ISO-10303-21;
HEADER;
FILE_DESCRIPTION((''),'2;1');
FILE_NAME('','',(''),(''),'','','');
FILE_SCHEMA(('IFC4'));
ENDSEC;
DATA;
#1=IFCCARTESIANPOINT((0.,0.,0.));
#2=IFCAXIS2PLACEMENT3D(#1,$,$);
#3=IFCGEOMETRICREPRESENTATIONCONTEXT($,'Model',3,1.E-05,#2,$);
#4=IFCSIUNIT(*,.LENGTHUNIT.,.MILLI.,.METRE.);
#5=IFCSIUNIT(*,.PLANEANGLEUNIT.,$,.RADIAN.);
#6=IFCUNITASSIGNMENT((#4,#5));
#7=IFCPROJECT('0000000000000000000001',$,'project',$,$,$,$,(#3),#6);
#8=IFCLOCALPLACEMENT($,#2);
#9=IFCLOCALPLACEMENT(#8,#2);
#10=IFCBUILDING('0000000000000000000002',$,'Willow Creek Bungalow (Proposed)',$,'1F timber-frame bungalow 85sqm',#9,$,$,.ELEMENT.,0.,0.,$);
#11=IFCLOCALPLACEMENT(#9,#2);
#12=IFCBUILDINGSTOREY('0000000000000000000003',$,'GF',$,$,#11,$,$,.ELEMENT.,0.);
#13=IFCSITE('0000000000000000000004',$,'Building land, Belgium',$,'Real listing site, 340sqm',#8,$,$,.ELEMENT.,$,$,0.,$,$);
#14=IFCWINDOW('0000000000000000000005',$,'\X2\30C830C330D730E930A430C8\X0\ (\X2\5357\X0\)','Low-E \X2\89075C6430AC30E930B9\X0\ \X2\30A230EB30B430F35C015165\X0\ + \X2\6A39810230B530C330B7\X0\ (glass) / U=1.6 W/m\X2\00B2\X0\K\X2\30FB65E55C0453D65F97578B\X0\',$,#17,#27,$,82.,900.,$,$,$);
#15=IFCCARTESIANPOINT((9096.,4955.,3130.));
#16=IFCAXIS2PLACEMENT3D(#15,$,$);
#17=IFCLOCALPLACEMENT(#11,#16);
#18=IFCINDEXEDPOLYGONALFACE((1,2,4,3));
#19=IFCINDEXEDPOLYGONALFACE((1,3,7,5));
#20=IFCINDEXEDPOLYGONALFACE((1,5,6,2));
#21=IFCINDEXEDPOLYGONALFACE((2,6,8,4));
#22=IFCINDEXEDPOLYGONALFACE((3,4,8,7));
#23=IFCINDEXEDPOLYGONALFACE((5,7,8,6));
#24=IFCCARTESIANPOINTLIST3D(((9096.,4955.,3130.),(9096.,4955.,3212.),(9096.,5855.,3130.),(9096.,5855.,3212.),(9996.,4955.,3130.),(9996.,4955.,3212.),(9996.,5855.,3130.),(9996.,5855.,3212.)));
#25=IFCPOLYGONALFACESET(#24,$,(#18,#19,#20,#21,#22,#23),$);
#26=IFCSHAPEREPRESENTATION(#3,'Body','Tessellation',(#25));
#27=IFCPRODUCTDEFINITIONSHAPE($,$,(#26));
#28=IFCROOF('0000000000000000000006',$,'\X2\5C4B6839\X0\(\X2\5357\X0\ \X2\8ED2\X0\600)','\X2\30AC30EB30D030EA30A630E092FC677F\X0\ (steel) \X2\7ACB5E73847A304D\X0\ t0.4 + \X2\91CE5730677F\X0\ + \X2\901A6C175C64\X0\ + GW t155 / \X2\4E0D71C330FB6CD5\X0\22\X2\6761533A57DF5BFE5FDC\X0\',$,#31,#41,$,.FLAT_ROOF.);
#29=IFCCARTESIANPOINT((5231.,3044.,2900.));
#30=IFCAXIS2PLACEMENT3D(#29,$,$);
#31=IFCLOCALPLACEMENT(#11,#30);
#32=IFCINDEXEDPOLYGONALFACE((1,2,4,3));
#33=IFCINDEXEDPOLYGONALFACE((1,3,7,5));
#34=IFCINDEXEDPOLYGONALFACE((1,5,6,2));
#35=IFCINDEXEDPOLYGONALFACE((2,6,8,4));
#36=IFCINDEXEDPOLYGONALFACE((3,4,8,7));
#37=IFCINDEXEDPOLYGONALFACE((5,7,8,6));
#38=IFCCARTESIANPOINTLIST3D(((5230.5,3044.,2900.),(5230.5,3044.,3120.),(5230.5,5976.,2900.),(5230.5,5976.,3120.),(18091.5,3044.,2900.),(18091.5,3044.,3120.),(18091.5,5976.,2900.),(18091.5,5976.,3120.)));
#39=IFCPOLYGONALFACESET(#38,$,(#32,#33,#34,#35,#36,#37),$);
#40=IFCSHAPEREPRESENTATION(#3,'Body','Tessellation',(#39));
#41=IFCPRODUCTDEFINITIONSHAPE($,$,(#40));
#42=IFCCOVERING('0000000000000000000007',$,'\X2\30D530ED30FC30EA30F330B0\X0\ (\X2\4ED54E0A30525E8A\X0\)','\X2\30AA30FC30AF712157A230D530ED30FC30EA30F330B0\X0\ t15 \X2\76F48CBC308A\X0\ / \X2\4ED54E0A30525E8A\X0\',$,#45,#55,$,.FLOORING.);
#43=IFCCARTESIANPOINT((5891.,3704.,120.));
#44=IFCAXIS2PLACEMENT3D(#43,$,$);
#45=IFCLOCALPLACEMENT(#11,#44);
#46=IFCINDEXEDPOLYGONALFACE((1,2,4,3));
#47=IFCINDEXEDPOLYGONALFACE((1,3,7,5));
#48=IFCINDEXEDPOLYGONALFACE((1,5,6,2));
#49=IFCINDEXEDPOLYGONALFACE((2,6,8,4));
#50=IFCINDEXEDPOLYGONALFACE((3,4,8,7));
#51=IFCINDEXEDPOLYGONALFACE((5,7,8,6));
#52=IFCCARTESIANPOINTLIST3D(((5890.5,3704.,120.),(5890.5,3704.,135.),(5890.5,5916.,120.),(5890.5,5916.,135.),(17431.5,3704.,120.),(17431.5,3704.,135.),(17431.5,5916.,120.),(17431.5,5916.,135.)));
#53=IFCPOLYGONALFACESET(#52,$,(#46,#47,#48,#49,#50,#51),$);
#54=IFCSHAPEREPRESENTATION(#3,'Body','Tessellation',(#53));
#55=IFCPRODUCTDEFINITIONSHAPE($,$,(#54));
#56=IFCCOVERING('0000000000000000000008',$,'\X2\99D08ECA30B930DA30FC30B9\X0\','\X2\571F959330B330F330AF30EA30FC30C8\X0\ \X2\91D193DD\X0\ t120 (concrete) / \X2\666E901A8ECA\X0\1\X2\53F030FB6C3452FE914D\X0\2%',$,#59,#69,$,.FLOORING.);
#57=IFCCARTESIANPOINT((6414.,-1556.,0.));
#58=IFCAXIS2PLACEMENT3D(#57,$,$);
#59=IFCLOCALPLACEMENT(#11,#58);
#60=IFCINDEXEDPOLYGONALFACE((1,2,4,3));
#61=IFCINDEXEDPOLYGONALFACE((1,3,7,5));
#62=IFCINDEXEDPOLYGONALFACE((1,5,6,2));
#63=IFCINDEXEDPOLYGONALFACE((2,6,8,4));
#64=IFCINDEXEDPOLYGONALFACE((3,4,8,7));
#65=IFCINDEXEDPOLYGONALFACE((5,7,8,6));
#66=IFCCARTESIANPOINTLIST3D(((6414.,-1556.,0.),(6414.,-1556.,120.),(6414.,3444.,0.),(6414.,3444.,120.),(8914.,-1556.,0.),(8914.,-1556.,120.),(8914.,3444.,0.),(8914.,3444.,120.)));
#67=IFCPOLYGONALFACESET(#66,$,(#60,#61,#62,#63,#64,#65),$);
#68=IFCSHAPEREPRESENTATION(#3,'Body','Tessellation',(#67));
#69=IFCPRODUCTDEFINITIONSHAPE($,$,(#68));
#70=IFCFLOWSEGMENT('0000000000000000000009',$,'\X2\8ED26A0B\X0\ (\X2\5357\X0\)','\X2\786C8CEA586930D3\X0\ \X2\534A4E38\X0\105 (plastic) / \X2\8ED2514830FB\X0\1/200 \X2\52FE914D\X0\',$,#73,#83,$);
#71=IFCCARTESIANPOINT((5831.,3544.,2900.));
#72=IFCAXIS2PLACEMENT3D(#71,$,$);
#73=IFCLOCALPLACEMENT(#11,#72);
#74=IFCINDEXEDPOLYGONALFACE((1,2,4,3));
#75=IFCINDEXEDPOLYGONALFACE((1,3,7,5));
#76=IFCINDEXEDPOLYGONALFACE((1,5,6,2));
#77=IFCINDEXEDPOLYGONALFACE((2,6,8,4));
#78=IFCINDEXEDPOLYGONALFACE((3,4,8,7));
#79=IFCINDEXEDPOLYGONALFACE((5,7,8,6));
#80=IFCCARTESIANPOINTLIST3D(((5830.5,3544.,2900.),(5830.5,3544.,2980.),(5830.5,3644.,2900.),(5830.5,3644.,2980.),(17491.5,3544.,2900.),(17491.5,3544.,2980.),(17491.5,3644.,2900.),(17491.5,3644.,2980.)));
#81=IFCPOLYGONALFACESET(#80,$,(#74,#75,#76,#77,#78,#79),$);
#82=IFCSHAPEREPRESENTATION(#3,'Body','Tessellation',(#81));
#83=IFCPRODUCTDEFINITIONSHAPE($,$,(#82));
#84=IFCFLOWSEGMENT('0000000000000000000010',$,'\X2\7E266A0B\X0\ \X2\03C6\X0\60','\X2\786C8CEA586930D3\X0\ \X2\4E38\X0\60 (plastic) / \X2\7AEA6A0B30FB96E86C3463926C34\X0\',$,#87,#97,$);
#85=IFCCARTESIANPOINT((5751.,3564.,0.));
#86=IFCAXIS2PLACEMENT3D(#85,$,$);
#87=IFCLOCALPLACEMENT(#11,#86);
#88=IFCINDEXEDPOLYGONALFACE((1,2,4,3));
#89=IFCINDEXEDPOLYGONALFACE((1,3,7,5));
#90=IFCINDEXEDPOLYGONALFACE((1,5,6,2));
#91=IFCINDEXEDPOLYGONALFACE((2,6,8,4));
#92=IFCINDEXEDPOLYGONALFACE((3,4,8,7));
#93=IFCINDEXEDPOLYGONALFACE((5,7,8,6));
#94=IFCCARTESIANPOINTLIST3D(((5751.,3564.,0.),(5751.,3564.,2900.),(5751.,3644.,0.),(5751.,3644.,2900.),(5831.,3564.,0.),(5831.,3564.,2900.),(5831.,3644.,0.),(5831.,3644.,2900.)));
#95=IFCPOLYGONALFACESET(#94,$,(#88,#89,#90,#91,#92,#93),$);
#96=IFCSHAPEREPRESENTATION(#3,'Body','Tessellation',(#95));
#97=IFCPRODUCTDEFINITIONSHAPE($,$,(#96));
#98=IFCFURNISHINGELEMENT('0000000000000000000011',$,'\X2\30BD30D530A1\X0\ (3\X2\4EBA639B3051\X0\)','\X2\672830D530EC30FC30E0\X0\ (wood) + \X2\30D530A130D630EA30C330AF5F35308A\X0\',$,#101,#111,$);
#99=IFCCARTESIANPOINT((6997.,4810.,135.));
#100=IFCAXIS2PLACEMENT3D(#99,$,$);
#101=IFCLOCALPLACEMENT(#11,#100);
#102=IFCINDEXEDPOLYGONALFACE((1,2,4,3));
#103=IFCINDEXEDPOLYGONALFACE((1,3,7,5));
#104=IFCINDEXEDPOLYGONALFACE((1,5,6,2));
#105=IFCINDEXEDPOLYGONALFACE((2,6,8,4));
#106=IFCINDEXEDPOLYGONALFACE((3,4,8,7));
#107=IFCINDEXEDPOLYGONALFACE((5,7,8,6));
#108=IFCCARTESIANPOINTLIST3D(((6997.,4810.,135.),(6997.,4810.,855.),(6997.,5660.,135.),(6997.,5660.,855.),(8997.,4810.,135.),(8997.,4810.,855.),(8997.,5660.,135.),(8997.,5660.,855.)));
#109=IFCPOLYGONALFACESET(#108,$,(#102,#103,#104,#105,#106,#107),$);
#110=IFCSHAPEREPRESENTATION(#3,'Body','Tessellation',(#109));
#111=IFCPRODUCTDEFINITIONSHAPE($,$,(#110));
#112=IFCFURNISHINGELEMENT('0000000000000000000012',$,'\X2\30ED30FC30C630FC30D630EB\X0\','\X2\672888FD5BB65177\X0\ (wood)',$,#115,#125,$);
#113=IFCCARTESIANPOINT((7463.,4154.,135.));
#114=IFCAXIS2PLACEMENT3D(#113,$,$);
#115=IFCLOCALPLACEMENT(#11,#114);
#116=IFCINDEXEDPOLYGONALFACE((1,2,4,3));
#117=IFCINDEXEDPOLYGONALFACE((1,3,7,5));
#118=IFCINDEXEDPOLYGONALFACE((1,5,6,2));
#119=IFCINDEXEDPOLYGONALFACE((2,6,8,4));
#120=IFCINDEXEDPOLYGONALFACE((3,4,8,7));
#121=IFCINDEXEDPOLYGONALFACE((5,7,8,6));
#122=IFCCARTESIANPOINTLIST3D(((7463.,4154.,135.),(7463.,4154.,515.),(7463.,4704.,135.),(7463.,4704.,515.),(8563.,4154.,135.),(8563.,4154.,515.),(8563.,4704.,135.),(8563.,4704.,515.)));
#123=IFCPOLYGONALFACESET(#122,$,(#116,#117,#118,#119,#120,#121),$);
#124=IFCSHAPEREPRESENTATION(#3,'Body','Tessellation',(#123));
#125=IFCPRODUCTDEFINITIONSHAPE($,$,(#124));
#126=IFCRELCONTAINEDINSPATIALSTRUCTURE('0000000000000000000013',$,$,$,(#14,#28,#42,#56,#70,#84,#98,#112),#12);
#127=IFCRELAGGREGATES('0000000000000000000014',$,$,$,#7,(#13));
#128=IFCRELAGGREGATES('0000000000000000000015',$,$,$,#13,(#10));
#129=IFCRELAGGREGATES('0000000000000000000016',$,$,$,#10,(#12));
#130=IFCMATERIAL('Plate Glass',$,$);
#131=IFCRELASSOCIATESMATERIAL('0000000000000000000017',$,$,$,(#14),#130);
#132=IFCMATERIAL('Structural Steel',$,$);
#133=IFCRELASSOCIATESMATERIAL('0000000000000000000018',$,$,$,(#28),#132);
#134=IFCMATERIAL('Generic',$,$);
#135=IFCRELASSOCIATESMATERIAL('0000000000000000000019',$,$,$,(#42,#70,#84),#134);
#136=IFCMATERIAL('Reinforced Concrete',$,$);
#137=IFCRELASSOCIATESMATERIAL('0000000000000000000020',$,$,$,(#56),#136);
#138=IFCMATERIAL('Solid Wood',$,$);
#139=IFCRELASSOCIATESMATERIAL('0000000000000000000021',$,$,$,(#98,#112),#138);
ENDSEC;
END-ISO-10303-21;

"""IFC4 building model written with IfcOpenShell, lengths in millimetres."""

from ifc_helpers import new_model, si_unit, frame, frame_2d, origin, place, context, project, spatial, rectangle, extrude, material, element, save


model = new_model("IFC4")

# Units and contexts
model_context = context("Model", 3, precision=1e-05, world=origin())
ifc_project = project(units=[si_unit("LENGTHUNIT", "METRE", prefix="MILLI"), si_unit("PLANEANGLEUNIT", "RADIAN")], contexts=[model_context])

# Site, building, storey
site_placement = place(None, origin())
site = spatial("IfcSite", under=ifc_project, at=site_placement, Name="Building land, Belgium", ObjectType="Real listing site, 340sqm", CompositionType="ELEMENT", RefElevation=0.0)
building_placement = place(site_placement, origin())
building = spatial("IfcBuilding", under=site, at=building_placement, Name="Willow Creek Bungalow (Proposed)", ObjectType="1F timber-frame bungalow 85sqm", CompositionType="ELEMENT", ElevationOfRefHeight=0.0, ElevationOfTerrain=0.0)
storey_placement = place(building_placement, origin())
storey = spatial("IfcBuildingStorey", under=building, at=storey_placement, Name="GF", CompositionType="ELEMENT", Elevation=0.0)

# Shared definitions
ifc_material_1 = material(Name="Solid Wood")

# Shared definitions
ifc_material_2 = material(Name="Reinforced Concrete")

# Shared definitions
ifc_material_3 = material(Name="Plate Glass")

# Window
window_1_placement = place(storey_placement, frame((9096.0, 4955.0, 3130.0)))
element("IfcWindow", 1, at=window_1_placement, inside=storey, material=ifc_material_3, Name="トップライト (南)", Description="Low-E 複層ガラス アルゴン封入 + 樹脂サッシ (glass) / U=1.6 W/m²K・日射取得型", OverallHeight=82.0, OverallWidth=900.0, context=model_context, shape_type="SweptSolid", body=[
    extrude(rectangle(XDim=900.0, YDim=900.0, at=frame_2d((450.0, 450.0))), frame((9096.0, 4955.0, 3130.0)), (0.0, 0.0, 1.0), 82.0),
])

# Roof
ifc_material_4 = material(Name="Structural Steel")
roof_1_placement = place(storey_placement, frame((5231.0, 3044.0, 2900.0)))
element("IfcRoof", 2, at=roof_1_placement, inside=storey, material=ifc_material_4, Name="屋根(南 軒600)", Description="ガルバリウム鋼板 (steel) 立平葺き t0.4 + 野地板 + 通気層 + GW t155 / 不燃・法22条区域対応", PredefinedType="FLAT_ROOF", context=model_context, shape_type="SweptSolid", body=[
    extrude(rectangle(XDim=12861.0, YDim=2932.0, at=frame_2d((6430.0, 1466.0))), frame((5231.0, 3044.0, 2900.0)), (0.0, 0.0, 1.0), 220.0),
])

# Coverings
ifc_material_5 = material(Name="Generic")
covering_1_placement = place(storey_placement, frame((5891.0, 3704.0, 120.0)))
element("IfcCovering", 3, at=covering_1_placement, inside=storey, material=ifc_material_5, Name="フローリング (仕上げ床)", Description="オーク無垢フローリング t15 直貼り / 仕上げ床", PredefinedType="FLOORING", context=model_context, shape_type="SweptSolid", body=[
    extrude(rectangle(XDim=11541.0, YDim=2212.0, at=frame_2d((5770.0, 1106.0))), frame((5891.0, 3704.0, 120.0)), (0.0, 0.0, 1.0), 15.0),
])
covering_2_placement = place(storey_placement, frame((6414.0, -1556.0, 0.0)))
element("IfcCovering", 4, at=covering_2_placement, inside=storey, material=ifc_material_2, Name="駐車スペース", Description="土間コンクリート 金鏝 t120 (concrete) / 普通車1台・水勾配2%", PredefinedType="FLOORING", context=model_context, shape_type="SweptSolid", body=[
    extrude(rectangle(XDim=2500.0, YDim=5000.0, at=frame_2d((1250.0, 2500.0))), frame((6414.0, -1556.0, 0.0)), (0.0, 0.0, 1.0), 120.0),
])

# Flow segments
flow_segment_1_placement = place(storey_placement, frame((5831.0, 3544.0, 2900.0)))
element("IfcFlowSegment", 5, at=flow_segment_1_placement, inside=storey, material=ifc_material_5, Name="軒樋 (南)", Description="硬質塩ビ 半丸105 (plastic) / 軒先・1/200 勾配", context=model_context, shape_type="SweptSolid", body=[
    extrude(rectangle(XDim=11661.0, YDim=100.0, at=frame_2d((5830.0, 50.0))), frame((5831.0, 3544.0, 2900.0)), (0.0, 0.0, 1.0), 80.0),
])
flow_segment_2_placement = place(storey_placement, frame((5751.0, 3564.0, 0.0)))
element("IfcFlowSegment", 6, at=flow_segment_2_placement, inside=storey, material=ifc_material_5, Name="縦樋 φ60", Description="硬質塩ビ 丸60 (plastic) / 竪樋・雨水排水", context=model_context, shape_type="SweptSolid", body=[
    extrude(rectangle(XDim=80.0, YDim=80.0, at=frame_2d((40.0, 40.0))), frame((5751.0, 3564.0, 0.0)), (0.0, 0.0, 1.0), 2900.0),
])

# Furnishing elements
furnishing_1_placement = place(storey_placement, frame((6997.0, 4810.0, 135.0)))
element("IfcFurnishingElement", 7, at=furnishing_1_placement, inside=storey, material=ifc_material_1, Name="ソファ (3人掛け)", Description="木フレーム (wood) + ファブリック張り", context=model_context, shape_type="SweptSolid", body=[
    extrude(rectangle(XDim=2000.0, YDim=850.0, at=frame_2d((1000.0, 425.0))), frame((6997.0, 4810.0, 135.0)), (0.0, 0.0, 1.0), 720.0),
])
furnishing_2_placement = place(storey_placement, frame((7463.0, 4154.0, 135.0)))
element("IfcFurnishingElement", 8, at=furnishing_2_placement, inside=storey, material=ifc_material_1, Name="ローテーブル", Description="木製家具 (wood)", context=model_context, shape_type="SweptSolid", body=[
    extrude(rectangle(XDim=1100.0, YDim=550.0, at=frame_2d((550.0, 275.0))), frame((7463.0, 4154.0, 135.0)), (0.0, 0.0, 1.0), 380.0),
])

save(model, "model.ifc")
